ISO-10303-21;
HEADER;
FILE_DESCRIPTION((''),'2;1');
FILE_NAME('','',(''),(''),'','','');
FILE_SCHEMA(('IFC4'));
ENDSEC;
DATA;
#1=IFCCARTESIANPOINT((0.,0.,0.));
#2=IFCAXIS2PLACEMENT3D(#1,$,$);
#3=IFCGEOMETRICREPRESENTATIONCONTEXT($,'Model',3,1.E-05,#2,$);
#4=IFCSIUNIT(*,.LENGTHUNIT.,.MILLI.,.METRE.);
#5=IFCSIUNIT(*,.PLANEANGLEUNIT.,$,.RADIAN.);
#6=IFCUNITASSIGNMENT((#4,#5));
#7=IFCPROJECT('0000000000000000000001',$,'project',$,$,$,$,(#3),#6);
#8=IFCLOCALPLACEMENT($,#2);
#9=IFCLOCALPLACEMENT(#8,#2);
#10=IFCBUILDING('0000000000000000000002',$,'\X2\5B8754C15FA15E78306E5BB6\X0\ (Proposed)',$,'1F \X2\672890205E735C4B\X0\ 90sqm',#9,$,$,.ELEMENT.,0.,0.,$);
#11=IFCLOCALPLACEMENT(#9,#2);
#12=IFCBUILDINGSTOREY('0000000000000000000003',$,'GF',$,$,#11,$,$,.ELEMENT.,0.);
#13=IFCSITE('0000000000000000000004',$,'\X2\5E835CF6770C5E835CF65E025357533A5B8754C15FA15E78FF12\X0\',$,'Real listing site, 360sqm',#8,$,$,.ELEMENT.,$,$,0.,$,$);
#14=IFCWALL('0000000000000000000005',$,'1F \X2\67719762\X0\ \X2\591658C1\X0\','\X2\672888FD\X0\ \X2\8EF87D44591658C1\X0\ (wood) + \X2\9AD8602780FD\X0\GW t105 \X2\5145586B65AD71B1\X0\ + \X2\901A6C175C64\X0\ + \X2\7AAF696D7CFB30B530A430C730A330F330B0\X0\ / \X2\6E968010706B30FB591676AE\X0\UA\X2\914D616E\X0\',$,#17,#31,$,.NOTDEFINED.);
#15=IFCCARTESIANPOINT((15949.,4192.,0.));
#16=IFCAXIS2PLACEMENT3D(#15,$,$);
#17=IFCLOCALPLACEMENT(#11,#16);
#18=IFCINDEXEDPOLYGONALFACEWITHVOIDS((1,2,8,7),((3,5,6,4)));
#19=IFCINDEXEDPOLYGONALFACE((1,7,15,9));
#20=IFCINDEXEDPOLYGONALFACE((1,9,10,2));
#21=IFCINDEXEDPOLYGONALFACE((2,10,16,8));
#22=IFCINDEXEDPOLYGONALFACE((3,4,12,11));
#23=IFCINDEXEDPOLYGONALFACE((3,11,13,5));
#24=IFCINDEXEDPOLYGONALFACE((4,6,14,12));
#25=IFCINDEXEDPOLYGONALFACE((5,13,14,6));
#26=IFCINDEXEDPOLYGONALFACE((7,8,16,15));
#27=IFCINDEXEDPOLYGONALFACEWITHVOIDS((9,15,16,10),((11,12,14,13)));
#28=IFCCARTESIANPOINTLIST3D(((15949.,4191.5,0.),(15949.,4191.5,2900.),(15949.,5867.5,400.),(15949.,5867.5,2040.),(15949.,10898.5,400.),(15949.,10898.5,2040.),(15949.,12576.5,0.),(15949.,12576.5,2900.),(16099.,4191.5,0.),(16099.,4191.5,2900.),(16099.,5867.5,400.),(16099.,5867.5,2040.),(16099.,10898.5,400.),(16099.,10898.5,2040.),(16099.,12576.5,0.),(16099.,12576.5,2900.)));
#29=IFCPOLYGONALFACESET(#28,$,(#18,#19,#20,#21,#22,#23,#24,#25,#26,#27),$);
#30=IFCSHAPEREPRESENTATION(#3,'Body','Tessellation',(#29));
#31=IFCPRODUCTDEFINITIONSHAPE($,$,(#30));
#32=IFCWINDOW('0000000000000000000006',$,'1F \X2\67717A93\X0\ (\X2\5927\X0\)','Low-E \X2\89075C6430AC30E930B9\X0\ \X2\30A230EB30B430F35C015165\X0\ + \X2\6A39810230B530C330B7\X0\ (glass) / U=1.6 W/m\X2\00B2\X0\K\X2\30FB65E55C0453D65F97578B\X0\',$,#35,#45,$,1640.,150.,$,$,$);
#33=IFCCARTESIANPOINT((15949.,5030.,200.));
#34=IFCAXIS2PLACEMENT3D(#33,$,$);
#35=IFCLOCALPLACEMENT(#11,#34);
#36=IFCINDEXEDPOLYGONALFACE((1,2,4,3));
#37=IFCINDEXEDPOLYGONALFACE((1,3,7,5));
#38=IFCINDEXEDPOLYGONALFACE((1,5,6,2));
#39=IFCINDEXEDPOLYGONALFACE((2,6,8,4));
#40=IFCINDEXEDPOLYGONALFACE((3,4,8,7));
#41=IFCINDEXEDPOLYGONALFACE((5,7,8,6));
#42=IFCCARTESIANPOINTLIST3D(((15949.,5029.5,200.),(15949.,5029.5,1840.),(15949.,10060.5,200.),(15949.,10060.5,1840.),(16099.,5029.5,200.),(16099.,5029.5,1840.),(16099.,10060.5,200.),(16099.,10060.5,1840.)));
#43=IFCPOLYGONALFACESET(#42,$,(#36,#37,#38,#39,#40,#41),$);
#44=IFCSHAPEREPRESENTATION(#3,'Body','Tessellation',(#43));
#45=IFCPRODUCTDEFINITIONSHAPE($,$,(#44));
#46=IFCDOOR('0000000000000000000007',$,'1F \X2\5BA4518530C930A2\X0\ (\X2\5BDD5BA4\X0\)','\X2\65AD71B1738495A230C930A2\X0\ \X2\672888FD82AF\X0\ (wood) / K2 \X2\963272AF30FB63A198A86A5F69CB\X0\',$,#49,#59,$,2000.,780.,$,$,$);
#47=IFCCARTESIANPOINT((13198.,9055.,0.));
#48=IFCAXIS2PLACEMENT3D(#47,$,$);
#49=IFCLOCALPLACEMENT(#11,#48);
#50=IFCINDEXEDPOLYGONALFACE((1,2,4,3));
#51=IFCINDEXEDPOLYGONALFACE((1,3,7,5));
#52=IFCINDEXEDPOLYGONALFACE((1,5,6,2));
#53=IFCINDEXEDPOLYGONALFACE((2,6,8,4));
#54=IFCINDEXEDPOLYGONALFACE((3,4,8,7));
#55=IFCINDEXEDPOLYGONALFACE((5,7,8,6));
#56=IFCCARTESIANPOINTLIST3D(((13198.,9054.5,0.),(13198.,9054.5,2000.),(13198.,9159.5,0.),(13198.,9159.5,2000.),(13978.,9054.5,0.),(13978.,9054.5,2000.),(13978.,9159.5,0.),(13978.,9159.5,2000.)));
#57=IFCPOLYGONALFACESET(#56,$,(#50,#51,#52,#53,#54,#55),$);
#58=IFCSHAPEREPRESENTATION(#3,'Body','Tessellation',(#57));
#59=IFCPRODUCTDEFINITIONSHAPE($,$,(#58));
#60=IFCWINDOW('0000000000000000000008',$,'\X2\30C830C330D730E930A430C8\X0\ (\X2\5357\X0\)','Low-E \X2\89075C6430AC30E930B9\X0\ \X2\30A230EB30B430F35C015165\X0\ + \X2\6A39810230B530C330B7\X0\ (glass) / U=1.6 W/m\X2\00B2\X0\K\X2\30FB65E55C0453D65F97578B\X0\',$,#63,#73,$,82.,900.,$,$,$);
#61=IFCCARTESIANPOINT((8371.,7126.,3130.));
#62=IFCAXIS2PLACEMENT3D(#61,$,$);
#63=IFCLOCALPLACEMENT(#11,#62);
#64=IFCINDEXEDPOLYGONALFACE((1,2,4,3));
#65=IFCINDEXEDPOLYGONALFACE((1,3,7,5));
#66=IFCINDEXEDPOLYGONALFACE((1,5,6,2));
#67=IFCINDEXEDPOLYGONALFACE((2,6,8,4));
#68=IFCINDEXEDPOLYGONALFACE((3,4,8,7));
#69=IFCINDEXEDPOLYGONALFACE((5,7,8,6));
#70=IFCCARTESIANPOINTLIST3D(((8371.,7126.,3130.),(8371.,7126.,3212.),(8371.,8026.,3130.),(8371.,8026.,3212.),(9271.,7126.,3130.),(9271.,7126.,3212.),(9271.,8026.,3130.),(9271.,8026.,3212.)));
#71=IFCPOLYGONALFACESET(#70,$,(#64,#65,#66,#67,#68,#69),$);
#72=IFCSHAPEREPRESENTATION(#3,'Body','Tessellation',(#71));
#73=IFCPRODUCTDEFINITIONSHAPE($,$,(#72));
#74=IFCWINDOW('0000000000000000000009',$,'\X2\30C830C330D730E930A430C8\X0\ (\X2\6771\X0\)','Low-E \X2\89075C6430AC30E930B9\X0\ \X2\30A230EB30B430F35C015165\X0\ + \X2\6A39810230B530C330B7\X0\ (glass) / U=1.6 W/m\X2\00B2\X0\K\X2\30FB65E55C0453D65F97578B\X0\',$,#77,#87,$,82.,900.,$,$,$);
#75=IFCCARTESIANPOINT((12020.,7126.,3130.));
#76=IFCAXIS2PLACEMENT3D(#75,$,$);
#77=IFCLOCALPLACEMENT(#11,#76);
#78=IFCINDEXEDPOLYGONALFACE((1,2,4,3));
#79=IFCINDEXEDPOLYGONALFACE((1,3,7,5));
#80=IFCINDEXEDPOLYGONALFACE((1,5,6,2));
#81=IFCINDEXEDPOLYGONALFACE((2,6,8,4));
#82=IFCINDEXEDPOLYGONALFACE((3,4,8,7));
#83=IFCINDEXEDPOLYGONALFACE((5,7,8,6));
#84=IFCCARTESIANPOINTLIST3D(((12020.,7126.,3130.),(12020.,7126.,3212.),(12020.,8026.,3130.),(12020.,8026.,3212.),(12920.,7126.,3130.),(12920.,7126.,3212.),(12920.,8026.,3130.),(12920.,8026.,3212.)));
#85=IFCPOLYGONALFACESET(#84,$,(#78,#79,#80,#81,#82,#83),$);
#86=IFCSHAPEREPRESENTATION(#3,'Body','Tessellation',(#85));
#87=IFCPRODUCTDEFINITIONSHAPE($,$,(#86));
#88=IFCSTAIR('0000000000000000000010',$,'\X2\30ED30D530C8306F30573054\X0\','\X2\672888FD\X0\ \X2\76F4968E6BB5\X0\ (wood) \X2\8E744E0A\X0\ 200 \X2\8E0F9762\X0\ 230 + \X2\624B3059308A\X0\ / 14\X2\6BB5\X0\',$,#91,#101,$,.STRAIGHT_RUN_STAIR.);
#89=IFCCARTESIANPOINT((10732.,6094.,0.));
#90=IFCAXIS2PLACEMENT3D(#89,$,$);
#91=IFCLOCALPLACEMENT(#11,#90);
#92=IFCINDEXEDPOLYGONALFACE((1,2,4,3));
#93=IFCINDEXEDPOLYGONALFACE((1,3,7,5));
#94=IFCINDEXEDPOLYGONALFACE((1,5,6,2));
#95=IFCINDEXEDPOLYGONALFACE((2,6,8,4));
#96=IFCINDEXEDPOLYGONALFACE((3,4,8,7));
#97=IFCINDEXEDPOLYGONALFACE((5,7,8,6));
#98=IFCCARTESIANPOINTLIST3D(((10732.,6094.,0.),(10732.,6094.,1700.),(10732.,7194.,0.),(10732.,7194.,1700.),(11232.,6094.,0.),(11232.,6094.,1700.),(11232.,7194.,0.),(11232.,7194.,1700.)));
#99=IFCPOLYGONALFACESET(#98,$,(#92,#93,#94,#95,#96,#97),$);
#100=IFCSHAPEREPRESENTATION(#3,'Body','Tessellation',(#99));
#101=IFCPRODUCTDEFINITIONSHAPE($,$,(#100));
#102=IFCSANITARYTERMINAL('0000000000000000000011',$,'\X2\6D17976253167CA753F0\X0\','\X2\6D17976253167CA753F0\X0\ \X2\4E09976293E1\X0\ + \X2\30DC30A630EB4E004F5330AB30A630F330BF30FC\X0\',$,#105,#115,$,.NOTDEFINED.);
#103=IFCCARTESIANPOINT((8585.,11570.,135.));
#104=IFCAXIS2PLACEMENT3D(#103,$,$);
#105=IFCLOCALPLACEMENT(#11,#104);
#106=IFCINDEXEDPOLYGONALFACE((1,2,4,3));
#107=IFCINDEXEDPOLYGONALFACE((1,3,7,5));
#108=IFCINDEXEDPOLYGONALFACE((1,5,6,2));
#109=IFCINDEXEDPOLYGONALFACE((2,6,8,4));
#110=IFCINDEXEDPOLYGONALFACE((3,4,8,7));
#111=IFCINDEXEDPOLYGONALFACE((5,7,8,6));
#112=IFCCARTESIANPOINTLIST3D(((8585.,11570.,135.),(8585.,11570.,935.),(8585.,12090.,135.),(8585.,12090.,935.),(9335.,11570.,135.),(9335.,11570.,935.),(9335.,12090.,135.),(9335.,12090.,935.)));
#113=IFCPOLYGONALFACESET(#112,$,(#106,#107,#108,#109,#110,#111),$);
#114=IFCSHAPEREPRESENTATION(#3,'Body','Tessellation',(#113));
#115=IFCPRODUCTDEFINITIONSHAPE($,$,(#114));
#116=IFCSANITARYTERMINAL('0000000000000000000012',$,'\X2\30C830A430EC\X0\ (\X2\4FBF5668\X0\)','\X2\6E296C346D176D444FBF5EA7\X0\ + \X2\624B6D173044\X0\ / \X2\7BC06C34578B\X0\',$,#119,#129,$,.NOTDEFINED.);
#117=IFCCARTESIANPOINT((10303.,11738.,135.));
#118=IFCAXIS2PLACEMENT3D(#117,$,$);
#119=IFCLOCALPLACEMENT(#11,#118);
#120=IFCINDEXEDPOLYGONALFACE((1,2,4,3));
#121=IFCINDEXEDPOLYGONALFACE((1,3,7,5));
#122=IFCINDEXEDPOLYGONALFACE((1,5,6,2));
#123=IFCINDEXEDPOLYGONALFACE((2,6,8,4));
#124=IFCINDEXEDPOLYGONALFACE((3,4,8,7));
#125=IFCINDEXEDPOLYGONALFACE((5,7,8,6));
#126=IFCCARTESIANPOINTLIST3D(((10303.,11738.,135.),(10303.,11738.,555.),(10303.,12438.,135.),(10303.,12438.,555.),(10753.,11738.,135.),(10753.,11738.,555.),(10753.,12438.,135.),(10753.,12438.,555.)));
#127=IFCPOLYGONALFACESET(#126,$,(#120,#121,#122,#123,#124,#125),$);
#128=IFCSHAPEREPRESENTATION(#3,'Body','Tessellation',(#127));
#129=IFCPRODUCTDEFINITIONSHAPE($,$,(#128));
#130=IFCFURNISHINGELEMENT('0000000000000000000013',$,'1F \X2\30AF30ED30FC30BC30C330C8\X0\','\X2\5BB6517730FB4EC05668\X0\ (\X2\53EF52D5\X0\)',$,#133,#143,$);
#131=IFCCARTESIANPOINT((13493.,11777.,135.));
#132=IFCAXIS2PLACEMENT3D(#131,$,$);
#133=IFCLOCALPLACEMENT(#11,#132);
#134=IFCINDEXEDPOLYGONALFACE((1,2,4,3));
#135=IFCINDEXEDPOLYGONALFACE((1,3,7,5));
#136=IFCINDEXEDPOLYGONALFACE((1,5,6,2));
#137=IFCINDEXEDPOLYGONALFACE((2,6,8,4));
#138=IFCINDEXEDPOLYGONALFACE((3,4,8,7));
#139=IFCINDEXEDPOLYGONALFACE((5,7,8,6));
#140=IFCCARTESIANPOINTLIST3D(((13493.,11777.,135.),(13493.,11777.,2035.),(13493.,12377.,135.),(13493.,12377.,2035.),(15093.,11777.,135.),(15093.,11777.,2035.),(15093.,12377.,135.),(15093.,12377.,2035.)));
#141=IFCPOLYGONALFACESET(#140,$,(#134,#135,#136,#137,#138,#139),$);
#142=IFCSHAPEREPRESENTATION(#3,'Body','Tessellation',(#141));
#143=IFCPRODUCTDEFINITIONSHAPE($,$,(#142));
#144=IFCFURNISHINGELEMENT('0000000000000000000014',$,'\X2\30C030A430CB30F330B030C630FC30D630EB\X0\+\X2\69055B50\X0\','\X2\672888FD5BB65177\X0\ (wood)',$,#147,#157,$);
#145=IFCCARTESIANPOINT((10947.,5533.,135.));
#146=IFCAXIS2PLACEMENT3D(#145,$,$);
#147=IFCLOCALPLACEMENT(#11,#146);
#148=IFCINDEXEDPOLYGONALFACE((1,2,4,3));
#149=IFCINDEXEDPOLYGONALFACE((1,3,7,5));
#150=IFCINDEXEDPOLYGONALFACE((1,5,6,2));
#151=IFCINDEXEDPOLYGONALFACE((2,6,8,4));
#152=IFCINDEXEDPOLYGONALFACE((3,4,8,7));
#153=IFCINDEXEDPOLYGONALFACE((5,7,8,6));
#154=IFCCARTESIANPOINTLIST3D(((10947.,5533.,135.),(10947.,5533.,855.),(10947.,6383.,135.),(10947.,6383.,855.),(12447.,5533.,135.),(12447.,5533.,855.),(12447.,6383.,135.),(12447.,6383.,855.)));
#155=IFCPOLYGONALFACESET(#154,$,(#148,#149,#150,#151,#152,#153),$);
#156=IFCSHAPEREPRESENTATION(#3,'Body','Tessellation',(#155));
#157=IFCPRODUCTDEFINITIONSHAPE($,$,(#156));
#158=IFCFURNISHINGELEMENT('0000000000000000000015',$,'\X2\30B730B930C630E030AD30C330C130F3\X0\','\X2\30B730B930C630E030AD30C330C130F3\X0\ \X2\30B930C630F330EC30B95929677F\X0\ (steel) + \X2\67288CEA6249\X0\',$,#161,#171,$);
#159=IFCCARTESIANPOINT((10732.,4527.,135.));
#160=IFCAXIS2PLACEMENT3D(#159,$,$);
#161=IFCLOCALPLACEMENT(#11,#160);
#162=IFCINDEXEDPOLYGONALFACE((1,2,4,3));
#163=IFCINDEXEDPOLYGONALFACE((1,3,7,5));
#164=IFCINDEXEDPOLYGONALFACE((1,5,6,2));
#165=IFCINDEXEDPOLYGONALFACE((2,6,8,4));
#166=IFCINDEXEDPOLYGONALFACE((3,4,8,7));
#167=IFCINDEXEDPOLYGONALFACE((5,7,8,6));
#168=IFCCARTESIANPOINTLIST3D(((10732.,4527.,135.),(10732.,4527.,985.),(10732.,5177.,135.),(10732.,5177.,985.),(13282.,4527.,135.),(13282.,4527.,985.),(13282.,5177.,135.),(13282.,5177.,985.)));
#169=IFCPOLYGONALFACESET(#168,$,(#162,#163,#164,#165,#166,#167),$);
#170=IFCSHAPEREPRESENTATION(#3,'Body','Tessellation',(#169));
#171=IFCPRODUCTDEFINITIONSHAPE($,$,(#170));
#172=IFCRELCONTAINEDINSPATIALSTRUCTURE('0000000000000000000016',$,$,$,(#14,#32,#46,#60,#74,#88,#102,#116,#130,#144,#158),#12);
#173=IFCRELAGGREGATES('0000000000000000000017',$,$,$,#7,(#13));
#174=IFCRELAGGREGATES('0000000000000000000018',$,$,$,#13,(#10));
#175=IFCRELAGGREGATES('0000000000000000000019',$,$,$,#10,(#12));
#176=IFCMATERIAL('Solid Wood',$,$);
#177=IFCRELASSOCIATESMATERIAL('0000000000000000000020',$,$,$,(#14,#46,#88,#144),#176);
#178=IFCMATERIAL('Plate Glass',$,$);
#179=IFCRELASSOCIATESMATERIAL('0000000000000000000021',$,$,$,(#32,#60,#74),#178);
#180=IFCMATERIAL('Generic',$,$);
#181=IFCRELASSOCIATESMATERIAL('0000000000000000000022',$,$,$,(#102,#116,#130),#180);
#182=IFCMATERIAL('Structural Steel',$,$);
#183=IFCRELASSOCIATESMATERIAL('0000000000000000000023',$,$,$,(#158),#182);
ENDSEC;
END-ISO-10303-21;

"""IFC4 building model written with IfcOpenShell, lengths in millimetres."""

from ifc_helpers import new_model, si_unit, frame, frame_2d, origin, place, context, project, spatial, rectangle, extrude, material, element, fill, save


model = new_model("IFC4")

# Units and contexts
model_context = context("Model", 3, precision=1e-05, world=origin())
ifc_project = project(units=[si_unit("LENGTHUNIT", "METRE", prefix="MILLI"), si_unit("PLANEANGLEUNIT", "RADIAN")], contexts=[model_context])

# Site, building, storey
site_placement = place(None, origin())
site = spatial("IfcSite", under=ifc_project, at=site_placement, Name="広島県広島市南区宇品御幸２", ObjectType="Real listing site, 360sqm", CompositionType="ELEMENT", RefElevation=0.0)
building_placement = place(site_placement, origin())
building = spatial("IfcBuilding", under=site, at=building_placement, Name="宇品御幸の家 (Proposed)", ObjectType="1F 木造平屋 90sqm", CompositionType="ELEMENT", ElevationOfRefHeight=0.0, ElevationOfTerrain=0.0)
storey_placement = place(building_placement, origin())
storey = spatial("IfcBuildingStorey", under=building, at=storey_placement, Name="GF", CompositionType="ELEMENT", Elevation=0.0)

# Wall, opening, window
ifc_material_1 = material(Name="Solid Wood")
wall_1_placement = place(storey_placement, frame((15949.0, 4192.0, 0.0)))
wall_1 = element("IfcWall", 1, at=wall_1_placement, inside=storey, material=ifc_material_1, Name="1F 東面 外壁", Description="木製 軸組外壁 (wood) + 高性能GW t105 充填断熱 + 通気層 + 窯業系サイディング / 準耐火・外皮UA配慮", PredefinedType="NOTDEFINED", context=model_context, shape_type="SweptSolid", body=[
    extrude(rectangle(XDim=150.0, YDim=8385.0, at=frame_2d((75.0, 4192.0))), frame((15949.0, 4192.0, 0.0)), (0.0, 0.0, 1.0), 2900.0),
])
opening_placement = place(storey_placement, frame((15949.0, 5030.0, 200.0)))
opening = element("IfcOpeningElement", 2, at=opening_placement, cuts=wall_1, PredefinedType="NOTDEFINED", context=model_context, shape_type="SweptSolid", body=[
    extrude(rectangle(XDim=150.0, YDim=5031.0, at=frame_2d((75.0, 2515.0))), frame((15949.0, 5030.0, 200.0)), (0.0, 0.0, 1.0), 1640.0),
])
ifc_material_2 = material(Name="Plate Glass")
window_1_placement = place(storey_placement, frame((15949.0, 5030.0, 200.0)))
window_1 = element("IfcWindow", 3, at=window_1_placement, inside=storey, material=ifc_material_2, Name="1F 東窓 (大)", Description="Low-E 複層ガラス アルゴン封入 + 樹脂サッシ (glass) / U=1.6 W/m²K・日射取得型", OverallHeight=1640.0, OverallWidth=150.0, context=model_context, shape_type="SweptSolid", body=[
    extrude(rectangle(XDim=150.0, YDim=5031.0, at=frame_2d((75.0, 2515.0))), frame((15949.0, 5030.0, 200.0)), (0.0, 0.0, 1.0), 1640.0),
])
fill(opening, window_1)

# Door
door_placement = place(storey_placement, frame((13198.0, 9055.0, 0.0)))
element("IfcDoor", 4, at=door_placement, inside=storey, material=ifc_material_1, Name="1F 室内ドア (寝室)", Description="断熱玄関ドア 木製芯 (wood) / K2 防犯・採風機構", OverallHeight=2000.0, OverallWidth=780.0, context=model_context, shape_type="SweptSolid", body=[
    extrude(rectangle(XDim=780.0, YDim=105.0, at=frame_2d((390.0, 52.0))), frame((13198.0, 9055.0, 0.0)), (0.0, 0.0, 1.0), 2000.0),
])

# Windows
window_2_placement = place(storey_placement, frame((8371.0, 7126.0, 3130.0)))
element("IfcWindow", 5, at=window_2_placement, inside=storey, material=ifc_material_2, Name="トップライト (南)", Description="Low-E 複層ガラス アルゴン封入 + 樹脂サッシ (glass) / U=1.6 W/m²K・日射取得型", OverallHeight=82.0, OverallWidth=900.0, context=model_context, shape_type="SweptSolid", body=[
    extrude(rectangle(XDim=900.0, YDim=900.0, at=frame_2d((450.0, 450.0))), frame((8371.0, 7126.0, 3130.0)), (0.0, 0.0, 1.0), 82.0),
])
window_3_placement = place(storey_placement, frame((12020.0, 7126.0, 3130.0)))
element("IfcWindow", 6, at=window_3_placement, inside=storey, material=ifc_material_2, Name="トップライト (東)", Description="Low-E 複層ガラス アルゴン封入 + 樹脂サッシ (glass) / U=1.6 W/m²K・日射取得型", OverallHeight=82.0, OverallWidth=900.0, context=model_context, shape_type="SweptSolid", body=[
    extrude(rectangle(XDim=900.0, YDim=900.0, at=frame_2d((450.0, 450.0))), frame((12020.0, 7126.0, 3130.0)), (0.0, 0.0, 1.0), 82.0),
])

# Stair
stair_placement = place(storey_placement, frame((10732.0, 6094.0, 0.0)))
element("IfcStair", 7, at=stair_placement, inside=storey, material=ifc_material_1, Name="ロフトはしご", Description="木製 直階段 (wood) 蹴上 200 踏面 230 + 手すり / 14段", PredefinedType="STRAIGHT_RUN_STAIR", context=model_context, shape_type="SweptSolid", body=[
    extrude(rectangle(XDim=500.0, YDim=1100.0, at=frame_2d((250.0, 550.0))), frame((10732.0, 6094.0, 0.0)), (0.0, 0.0, 1.0), 1700.0),
])

# Sanitary terminals
ifc_material_3 = material(Name="Generic")
sanitary_terminal_1_placement = place(storey_placement, frame((8585.0, 11570.0, 135.0)))
element("IfcSanitaryTerminal", 8, at=sanitary_terminal_1_placement, inside=storey, material=ifc_material_3, Name="洗面化粧台", Description="洗面化粧台 三面鏡 + ボウル一体カウンター", PredefinedType="NOTDEFINED", context=model_context, shape_type="SweptSolid", body=[
    extrude(rectangle(XDim=750.0, YDim=520.0, at=frame_2d((375.0, 260.0))), frame((8585.0, 11570.0, 135.0)), (0.0, 0.0, 1.0), 800.0),
])
sanitary_terminal_2_placement = place(storey_placement, frame((10303.0, 11738.0, 135.0)))
element("IfcSanitaryTerminal", 9, at=sanitary_terminal_2_placement, inside=storey, material=ifc_material_3, Name="トイレ (便器)", Description="温水洗浄便座 + 手洗い / 節水型", PredefinedType="NOTDEFINED", context=model_context, shape_type="SweptSolid", body=[
    extrude(rectangle(XDim=450.0, YDim=700.0, at=frame_2d((225.0, 350.0))), frame((10303.0, 11738.0, 135.0)), (0.0, 0.0, 1.0), 420.0),
])

# Furnishing elements
furnishing_1_placement = place(storey_placement, frame((13493.0, 11777.0, 135.0)))
element("IfcFurnishingElement", 10, at=furnishing_1_placement, inside=storey, material=ifc_material_3, Name="1F クローゼット", Description="家具・什器 (可動)", context=model_context, shape_type="SweptSolid", body=[
    extrude(rectangle(XDim=1600.0, YDim=600.0, at=frame_2d((800.0, 300.0))), frame((13493.0, 11777.0, 135.0)), (0.0, 0.0, 1.0), 1900.0),
])
furnishing_2_placement = place(storey_placement, frame((10947.0, 5533.0, 135.0)))
element("IfcFurnishingElement", 11, at=furnishing_2_placement, inside=storey, material=ifc_material_1, Name="ダイニングテーブル+椅子", Description="木製家具 (wood)", context=model_context, shape_type="SweptSolid", body=[
    extrude(rectangle(XDim=1500.0, YDim=850.0, at=frame_2d((750.0, 425.0))), frame((10947.0, 5533.0, 135.0)), (0.0, 0.0, 1.0), 720.0),
])
ifc_material_4 = material(Name="Structural Steel")
furnishing_3_placement = place(storey_placement, frame((10732.0, 4527.0, 135.0)))
element("IfcFurnishingElement", 12, at=furnishing_3_placement, inside=storey, material=ifc_material_4, Name="システムキッチン", Description="システムキッチン ステンレス天板 (steel) + 木質扉", context=model_context, shape_type="SweptSolid", body=[
    extrude(rectangle(XDim=2550.0, YDim=650.0, at=frame_2d((1275.0, 325.0))), frame((10732.0, 4527.0, 135.0)), (0.0, 0.0, 1.0), 850.0),
])

save(model, "model.ifc")
